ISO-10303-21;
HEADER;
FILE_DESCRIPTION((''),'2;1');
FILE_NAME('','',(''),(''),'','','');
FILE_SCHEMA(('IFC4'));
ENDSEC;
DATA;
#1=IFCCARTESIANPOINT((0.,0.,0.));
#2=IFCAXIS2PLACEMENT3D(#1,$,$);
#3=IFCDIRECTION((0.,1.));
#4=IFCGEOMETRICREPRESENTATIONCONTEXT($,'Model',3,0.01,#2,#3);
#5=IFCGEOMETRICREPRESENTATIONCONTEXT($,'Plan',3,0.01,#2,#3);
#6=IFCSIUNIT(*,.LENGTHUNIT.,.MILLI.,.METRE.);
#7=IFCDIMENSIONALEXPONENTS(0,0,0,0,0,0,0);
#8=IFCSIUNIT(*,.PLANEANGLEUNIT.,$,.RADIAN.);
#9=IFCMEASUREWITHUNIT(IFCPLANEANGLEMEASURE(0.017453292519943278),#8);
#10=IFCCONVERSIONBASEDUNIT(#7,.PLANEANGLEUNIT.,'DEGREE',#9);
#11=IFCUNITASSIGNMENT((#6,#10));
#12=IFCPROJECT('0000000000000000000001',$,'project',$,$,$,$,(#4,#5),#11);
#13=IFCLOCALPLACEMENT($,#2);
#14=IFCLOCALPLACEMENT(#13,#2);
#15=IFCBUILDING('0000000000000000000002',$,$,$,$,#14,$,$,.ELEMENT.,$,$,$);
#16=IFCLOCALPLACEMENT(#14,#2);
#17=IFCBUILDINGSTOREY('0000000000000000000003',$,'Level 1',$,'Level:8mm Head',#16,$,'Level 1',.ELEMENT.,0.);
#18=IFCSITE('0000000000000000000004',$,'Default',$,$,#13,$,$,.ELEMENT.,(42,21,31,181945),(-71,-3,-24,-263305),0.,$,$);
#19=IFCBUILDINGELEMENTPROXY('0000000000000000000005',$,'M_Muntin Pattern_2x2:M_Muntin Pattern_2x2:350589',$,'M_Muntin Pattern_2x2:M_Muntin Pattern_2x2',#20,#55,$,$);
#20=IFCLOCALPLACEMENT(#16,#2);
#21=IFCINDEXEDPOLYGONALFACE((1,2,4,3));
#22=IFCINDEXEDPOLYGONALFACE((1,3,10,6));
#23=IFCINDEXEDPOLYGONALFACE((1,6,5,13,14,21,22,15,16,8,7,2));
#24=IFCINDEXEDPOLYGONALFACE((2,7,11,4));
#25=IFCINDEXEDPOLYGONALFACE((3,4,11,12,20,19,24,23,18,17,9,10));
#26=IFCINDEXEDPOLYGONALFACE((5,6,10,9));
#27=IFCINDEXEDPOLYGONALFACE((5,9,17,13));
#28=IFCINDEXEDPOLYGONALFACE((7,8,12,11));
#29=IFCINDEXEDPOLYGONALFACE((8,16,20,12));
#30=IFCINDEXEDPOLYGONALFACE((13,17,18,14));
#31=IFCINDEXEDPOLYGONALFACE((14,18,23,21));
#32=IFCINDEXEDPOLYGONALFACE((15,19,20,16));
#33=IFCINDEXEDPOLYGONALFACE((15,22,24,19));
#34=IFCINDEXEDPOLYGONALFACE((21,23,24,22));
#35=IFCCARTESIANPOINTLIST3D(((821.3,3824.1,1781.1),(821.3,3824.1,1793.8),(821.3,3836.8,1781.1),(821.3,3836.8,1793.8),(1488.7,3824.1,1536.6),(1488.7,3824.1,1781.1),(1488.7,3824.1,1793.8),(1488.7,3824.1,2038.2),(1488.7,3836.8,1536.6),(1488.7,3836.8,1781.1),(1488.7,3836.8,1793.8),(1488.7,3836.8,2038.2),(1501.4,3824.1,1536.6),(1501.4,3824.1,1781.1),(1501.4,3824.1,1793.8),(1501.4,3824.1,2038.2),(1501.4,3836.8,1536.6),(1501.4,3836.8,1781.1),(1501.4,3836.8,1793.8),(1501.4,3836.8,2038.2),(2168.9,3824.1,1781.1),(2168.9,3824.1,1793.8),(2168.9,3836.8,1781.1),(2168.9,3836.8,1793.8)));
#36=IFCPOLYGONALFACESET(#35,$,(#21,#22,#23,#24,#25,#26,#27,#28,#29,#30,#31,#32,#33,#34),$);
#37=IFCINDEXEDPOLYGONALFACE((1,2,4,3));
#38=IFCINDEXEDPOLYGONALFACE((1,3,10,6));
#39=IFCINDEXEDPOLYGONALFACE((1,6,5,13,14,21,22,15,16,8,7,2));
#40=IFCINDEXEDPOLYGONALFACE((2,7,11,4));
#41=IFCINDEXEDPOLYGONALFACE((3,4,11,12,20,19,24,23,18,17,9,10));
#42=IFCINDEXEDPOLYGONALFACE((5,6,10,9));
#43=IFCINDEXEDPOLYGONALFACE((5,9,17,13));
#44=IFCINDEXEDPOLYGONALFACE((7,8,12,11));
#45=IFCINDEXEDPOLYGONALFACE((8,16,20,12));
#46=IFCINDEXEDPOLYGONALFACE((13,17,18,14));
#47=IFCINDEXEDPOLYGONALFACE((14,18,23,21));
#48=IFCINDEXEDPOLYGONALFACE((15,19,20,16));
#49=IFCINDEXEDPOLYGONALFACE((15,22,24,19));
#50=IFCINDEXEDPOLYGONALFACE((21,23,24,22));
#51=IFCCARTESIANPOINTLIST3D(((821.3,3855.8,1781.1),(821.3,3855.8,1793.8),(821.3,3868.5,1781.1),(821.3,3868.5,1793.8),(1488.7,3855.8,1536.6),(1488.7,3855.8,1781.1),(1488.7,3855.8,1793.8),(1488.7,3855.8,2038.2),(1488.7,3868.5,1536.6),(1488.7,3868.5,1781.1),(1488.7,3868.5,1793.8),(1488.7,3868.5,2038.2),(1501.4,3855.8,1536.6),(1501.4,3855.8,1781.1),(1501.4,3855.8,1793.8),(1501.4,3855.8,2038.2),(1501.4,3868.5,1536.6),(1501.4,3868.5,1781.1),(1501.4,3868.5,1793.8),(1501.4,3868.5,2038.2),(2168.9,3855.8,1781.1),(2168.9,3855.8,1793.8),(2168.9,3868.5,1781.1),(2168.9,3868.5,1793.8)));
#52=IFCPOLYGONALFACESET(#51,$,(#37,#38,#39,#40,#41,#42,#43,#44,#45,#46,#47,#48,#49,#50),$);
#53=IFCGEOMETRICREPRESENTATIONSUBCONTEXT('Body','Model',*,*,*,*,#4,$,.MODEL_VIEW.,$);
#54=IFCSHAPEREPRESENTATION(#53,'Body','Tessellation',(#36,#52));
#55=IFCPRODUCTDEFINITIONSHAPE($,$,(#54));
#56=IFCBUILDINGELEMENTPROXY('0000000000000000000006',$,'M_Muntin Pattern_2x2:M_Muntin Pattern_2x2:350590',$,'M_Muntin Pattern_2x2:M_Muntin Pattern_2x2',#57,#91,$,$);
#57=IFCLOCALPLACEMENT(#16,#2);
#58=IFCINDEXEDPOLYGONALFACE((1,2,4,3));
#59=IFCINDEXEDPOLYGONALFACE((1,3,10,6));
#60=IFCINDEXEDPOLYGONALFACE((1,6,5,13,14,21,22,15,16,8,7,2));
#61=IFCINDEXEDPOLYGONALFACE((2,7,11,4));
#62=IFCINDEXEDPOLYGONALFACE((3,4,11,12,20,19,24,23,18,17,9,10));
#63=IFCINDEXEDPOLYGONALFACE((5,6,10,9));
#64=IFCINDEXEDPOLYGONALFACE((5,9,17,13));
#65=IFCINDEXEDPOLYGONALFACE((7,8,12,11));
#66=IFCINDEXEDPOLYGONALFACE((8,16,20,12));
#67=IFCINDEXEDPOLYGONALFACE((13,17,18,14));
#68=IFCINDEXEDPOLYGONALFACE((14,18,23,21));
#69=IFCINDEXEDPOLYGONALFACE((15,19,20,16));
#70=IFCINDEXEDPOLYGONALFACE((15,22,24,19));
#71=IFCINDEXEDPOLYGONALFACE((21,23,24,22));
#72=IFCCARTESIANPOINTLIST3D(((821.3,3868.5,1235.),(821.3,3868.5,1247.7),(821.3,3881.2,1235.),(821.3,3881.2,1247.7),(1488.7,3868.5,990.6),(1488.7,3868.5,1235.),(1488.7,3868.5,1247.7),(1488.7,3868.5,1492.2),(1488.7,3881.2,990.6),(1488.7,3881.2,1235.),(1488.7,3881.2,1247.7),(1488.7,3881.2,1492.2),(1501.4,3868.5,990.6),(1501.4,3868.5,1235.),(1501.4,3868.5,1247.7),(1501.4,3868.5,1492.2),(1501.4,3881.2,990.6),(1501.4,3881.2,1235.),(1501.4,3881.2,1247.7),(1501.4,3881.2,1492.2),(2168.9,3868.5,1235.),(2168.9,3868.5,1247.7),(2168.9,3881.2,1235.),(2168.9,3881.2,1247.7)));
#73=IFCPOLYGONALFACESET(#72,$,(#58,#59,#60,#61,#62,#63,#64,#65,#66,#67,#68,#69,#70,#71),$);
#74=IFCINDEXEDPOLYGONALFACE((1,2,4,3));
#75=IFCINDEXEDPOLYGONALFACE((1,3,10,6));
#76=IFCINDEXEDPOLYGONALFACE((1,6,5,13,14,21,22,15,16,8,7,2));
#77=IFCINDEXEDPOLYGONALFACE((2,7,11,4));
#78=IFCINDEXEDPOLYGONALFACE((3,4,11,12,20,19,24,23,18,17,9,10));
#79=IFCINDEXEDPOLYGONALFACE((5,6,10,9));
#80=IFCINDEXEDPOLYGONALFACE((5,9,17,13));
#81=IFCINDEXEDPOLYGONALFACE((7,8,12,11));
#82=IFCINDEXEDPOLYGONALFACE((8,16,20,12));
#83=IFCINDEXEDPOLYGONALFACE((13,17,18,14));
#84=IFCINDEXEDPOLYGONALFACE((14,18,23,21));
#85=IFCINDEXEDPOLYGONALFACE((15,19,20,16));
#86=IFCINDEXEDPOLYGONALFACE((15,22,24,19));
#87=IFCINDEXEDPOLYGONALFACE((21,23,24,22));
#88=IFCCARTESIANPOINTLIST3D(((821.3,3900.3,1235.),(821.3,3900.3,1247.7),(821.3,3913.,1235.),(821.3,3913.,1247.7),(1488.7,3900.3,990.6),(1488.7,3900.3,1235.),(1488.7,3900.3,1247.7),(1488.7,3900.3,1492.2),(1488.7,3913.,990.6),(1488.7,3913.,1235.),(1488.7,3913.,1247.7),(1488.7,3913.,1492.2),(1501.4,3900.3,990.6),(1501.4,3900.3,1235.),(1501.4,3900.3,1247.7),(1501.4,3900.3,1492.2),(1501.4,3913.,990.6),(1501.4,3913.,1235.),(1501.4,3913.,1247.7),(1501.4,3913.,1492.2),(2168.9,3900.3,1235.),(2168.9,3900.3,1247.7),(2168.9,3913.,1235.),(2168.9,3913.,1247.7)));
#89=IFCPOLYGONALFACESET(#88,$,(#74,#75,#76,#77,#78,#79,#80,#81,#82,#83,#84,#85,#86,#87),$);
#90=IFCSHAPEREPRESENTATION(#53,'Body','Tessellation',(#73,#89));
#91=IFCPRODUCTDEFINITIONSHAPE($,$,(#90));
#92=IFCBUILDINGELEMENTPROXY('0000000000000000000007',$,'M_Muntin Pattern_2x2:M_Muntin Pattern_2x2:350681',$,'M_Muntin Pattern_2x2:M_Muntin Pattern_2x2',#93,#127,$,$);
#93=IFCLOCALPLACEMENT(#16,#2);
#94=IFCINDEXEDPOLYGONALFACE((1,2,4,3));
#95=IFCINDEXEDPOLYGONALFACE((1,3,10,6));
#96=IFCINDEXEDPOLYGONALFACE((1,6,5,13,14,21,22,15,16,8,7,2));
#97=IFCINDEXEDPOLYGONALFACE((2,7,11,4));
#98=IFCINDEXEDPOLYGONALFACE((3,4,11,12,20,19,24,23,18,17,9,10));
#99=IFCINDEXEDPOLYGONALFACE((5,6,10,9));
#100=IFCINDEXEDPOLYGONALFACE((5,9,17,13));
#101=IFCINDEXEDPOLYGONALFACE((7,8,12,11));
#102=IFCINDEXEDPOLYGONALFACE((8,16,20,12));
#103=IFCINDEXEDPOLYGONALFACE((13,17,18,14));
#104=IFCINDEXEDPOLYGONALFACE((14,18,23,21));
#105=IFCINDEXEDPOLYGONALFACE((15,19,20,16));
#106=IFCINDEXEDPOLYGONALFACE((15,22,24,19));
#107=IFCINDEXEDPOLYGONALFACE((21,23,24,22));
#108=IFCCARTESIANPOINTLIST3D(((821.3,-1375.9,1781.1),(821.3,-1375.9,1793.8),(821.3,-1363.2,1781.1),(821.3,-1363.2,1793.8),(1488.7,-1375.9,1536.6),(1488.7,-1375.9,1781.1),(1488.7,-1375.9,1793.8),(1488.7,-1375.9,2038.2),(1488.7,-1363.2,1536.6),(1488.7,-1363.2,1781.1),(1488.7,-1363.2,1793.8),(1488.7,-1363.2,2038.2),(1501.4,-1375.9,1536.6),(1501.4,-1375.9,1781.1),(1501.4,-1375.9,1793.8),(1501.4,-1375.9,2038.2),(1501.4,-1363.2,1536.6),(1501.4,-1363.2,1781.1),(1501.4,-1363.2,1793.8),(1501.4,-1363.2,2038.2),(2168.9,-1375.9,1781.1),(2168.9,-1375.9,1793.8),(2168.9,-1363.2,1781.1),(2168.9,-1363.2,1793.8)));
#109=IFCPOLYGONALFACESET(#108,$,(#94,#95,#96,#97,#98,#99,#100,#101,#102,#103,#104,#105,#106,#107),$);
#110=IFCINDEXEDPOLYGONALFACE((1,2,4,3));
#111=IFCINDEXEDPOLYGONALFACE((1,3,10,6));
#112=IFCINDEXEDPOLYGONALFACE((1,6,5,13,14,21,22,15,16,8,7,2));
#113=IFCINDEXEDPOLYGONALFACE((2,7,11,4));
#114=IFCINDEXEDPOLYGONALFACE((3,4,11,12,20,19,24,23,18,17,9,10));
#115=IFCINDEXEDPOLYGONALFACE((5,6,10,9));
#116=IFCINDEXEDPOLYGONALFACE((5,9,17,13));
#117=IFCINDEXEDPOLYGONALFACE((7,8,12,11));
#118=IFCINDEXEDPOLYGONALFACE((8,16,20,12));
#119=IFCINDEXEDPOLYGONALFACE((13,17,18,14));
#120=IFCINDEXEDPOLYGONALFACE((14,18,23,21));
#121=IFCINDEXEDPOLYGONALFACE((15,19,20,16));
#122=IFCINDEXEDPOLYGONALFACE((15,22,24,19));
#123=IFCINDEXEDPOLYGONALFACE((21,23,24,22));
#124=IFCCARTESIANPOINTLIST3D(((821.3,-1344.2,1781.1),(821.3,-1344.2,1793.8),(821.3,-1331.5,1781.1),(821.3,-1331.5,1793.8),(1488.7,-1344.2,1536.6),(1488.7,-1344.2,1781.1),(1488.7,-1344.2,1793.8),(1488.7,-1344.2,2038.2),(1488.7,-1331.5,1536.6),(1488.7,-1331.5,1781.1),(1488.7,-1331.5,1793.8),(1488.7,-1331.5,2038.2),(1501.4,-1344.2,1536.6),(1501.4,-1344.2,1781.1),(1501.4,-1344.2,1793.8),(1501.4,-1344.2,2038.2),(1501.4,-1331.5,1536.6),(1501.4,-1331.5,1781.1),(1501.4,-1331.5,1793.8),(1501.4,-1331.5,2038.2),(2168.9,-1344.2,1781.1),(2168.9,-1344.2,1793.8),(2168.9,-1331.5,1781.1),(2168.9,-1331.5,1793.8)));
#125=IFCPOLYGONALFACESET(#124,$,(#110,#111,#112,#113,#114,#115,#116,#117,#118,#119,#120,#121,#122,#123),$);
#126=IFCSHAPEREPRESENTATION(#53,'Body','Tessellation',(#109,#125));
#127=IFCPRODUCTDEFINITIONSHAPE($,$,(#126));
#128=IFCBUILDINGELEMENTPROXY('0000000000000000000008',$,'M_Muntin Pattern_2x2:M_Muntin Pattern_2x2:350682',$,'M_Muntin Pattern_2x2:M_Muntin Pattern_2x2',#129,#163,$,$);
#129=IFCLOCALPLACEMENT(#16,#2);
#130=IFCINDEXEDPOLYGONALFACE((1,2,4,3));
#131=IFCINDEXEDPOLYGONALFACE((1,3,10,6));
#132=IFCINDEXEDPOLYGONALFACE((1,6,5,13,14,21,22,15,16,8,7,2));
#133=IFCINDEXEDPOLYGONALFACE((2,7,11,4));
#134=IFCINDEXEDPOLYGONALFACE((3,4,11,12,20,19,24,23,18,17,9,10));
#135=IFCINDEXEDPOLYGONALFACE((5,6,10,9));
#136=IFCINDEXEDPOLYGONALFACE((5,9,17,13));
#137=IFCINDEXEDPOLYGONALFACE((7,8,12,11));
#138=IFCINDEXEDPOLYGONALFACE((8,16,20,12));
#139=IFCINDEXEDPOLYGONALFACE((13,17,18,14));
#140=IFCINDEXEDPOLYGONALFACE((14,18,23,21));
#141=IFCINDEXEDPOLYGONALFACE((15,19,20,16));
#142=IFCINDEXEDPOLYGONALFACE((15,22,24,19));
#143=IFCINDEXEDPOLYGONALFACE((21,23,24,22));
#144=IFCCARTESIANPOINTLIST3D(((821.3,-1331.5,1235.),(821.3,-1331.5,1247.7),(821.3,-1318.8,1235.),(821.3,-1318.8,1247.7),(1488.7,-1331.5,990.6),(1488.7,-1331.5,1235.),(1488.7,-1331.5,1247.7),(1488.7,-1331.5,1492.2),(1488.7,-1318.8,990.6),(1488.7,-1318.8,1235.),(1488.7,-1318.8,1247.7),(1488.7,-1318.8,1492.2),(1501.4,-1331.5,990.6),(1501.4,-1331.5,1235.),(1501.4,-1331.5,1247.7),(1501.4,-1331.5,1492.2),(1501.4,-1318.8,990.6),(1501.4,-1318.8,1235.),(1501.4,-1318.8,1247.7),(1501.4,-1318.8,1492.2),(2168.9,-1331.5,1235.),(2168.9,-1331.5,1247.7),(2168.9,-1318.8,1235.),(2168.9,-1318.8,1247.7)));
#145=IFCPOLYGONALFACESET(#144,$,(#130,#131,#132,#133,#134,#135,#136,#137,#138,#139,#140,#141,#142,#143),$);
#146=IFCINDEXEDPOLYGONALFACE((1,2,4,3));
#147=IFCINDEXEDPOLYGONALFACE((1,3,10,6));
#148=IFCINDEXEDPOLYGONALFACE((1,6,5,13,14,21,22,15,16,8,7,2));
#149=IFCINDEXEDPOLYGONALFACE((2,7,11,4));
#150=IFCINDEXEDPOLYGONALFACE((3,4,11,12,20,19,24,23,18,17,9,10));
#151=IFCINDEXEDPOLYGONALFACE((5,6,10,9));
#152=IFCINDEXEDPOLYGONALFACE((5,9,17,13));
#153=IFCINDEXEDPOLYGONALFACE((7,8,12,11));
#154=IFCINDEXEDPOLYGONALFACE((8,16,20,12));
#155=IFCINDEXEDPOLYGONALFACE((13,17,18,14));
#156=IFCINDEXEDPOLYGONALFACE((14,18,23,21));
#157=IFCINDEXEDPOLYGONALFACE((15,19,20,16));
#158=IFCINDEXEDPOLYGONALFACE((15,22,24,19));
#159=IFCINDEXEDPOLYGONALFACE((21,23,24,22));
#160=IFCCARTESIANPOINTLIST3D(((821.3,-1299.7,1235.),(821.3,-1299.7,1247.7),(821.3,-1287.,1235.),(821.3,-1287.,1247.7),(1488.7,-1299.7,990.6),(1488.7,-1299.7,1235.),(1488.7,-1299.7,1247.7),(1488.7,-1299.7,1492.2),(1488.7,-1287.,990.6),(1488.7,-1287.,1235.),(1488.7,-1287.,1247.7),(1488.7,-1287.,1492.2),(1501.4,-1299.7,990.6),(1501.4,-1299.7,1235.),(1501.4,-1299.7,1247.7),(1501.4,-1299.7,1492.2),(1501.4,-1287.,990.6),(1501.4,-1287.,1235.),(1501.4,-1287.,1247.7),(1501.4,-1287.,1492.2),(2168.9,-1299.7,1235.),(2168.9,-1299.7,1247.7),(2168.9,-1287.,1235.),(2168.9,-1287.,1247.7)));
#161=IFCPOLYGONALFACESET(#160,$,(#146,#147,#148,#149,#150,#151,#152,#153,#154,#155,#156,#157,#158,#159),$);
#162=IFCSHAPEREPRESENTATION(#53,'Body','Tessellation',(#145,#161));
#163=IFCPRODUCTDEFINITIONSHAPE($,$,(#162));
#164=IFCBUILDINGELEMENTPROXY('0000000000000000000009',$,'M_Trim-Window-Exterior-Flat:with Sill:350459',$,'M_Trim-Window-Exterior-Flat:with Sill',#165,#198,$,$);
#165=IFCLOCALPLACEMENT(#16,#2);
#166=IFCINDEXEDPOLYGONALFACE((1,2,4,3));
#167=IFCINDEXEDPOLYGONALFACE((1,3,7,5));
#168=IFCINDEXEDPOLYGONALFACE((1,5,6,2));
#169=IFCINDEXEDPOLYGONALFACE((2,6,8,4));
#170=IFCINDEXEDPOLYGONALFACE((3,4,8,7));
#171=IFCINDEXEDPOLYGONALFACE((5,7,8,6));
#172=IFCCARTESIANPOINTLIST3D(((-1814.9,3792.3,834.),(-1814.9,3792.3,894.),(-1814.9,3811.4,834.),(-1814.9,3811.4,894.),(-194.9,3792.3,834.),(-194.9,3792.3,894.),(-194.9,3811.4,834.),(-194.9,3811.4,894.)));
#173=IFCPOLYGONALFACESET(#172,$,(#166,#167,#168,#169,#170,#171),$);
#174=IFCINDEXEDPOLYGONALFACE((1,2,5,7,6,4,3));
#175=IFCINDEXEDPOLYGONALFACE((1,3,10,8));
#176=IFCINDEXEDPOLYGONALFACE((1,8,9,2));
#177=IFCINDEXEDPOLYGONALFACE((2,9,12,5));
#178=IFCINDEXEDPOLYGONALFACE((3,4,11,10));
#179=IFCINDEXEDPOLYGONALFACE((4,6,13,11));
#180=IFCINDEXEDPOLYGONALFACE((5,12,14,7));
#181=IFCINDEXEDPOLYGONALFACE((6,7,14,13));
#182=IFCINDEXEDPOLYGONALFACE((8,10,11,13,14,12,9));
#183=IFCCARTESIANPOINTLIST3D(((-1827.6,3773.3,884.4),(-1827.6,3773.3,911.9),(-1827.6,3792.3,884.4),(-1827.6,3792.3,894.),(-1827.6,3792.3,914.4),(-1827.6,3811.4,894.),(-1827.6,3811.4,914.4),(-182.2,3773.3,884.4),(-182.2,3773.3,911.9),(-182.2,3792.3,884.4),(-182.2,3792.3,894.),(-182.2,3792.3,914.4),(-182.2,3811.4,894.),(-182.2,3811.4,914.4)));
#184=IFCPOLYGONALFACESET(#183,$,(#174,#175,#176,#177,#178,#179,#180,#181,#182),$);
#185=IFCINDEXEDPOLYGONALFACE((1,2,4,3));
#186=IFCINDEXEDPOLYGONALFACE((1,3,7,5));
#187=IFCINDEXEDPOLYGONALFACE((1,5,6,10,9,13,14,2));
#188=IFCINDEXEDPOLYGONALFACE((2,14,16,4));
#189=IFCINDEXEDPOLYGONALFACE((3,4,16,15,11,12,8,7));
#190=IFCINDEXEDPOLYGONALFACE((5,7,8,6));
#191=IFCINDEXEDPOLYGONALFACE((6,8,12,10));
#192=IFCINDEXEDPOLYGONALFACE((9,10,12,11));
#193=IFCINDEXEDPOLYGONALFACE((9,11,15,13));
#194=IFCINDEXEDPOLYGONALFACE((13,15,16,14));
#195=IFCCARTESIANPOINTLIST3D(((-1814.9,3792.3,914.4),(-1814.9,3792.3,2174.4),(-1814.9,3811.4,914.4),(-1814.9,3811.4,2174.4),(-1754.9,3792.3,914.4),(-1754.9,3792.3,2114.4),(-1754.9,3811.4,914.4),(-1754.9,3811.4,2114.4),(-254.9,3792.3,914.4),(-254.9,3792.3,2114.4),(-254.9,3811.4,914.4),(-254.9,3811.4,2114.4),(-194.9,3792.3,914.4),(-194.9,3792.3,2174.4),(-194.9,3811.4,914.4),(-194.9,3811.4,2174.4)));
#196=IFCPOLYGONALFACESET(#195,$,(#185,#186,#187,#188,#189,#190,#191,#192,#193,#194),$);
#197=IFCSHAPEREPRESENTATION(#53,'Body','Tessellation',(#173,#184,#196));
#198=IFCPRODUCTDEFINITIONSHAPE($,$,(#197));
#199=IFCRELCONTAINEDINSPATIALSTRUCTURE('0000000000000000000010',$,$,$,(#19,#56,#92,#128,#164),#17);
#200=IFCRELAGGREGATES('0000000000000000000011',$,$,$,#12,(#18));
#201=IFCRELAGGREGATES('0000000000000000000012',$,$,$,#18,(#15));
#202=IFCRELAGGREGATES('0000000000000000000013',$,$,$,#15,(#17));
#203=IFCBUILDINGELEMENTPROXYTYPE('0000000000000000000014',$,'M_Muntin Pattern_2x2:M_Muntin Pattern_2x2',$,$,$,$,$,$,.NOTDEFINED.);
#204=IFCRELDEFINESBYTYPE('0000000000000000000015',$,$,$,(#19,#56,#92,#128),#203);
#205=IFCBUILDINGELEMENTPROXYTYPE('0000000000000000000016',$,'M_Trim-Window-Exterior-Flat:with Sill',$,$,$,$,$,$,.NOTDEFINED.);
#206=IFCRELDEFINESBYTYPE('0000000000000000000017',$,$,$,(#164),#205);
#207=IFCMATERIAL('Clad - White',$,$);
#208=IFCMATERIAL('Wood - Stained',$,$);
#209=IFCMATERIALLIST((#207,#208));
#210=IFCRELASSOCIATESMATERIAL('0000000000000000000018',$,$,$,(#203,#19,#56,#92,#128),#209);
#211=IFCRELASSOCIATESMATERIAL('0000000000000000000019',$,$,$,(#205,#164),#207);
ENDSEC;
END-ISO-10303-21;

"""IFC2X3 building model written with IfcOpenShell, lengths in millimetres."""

from ifc_helpers import new_model, entity, si_unit, converted_unit, direction, frame, frame_2d, origin, place, context, subcontext, project, spatial, polyline, rectangle, outline, extrude, source, transform, mapped, material, material_list, type_object, type_shapes, element, save


model = new_model("IFC2X3")

# Units and contexts
model_context = context("Model", 3, precision=0.01, world=origin(), true_north=direction((0.0, 1.0)))
plan_context = context("Plan", 3, precision=0.01, world=origin(), true_north=direction((0.0, 1.0)))
body_context = subcontext(model_context, "Body", "Model", "MODEL_VIEW")
ifc_project = project(units=[si_unit("LENGTHUNIT", "METRE", prefix="MILLI"), converted_unit("PLANEANGLEUNIT", "DEGREE", entity("IfcPlaneAngleMeasure", 0.017453292519943278), si_unit("PLANEANGLEUNIT", "RADIAN"), dimensions=[0, 0, 0, 0, 0, 0, 0])], contexts=[model_context, plan_context])

# Site, building, storey
site_placement = place(None, origin())
site = spatial("IfcSite", under=ifc_project, at=site_placement, Name="Default", CompositionType="ELEMENT", RefLatitude=(42, 21, 31, 181945), RefLongitude=(-71, -3, -24, -263305), RefElevation=0.0)
building_placement = place(site_placement, origin())
building = spatial("IfcBuilding", under=site, at=building_placement, CompositionType="ELEMENT")
storey_placement = place(building_placement, origin())
storey = spatial("IfcBuildingStorey", under=building, at=storey_placement, Name="Level 1", ObjectType="Level:8mm Head", LongName="Level 1", CompositionType="ELEMENT", Elevation=0.0)

# Shared definitions
ifc_material_1 = material(Name="Wood - Stained")

# Building element proxies
ifc_material_2 = material(Name="Clad - White")
ifc_material_list_1 = material_list([ifc_material_2, ifc_material_1])
building_element_proxy_type_1 = type_object("IfcBuildingElementProxyType", Name="M_Muntin Pattern_2x2:M_Muntin Pattern_2x2", PredefinedType="NOTDEFINED", material=ifc_material_list_1)
shared_shape_1 = source(origin(), body_context, "Body", "SweptSolid", [
    extrude(outline(polyline([(6.4, -6.4), (250.8, -6.4), (250.8, 6.3), (6.4, 6.3), (6.4, 673.8), (-6.3, 673.8), (-6.3, 6.3), (-250.8, 6.3), (-250.8, -6.4), (-6.3, -6.4), (-6.3, -673.8), (6.4, -673.8), (6.4, -6.4)])), frame((0.0, 9.5, 250.8), z_axis=(0.0, 1.0, 0.0), x_axis=(0.0, 0.0, 1.0)), (0.0, 0.0, 1.0), 12.7),
    extrude(outline(polyline([(6.4, -6.4), (250.8, -6.4), (250.8, 6.3), (6.4, 6.3), (6.4, 673.8), (-6.3, 673.8), (-6.3, 6.3), (-250.8, 6.3), (-250.8, -6.4), (-6.3, -6.4), (-6.3, -673.8), (6.4, -673.8), (6.4, -6.4)])), frame((0.0, -22.2, 250.8), z_axis=(0.0, 1.0, 0.0), x_axis=(0.0, 0.0, 1.0)), (0.0, 0.0, 1.0), 12.7),
])
type_shapes(building_element_proxy_type_1, [shared_shape_1])
for number, where, z_axis, x_axis, name in (
    (1, (1495.1, 3846.3, 1536.6), (0.0, 0.0, 1.0), (-1.0, 0.0, 0.0), "M_Muntin Pattern_2x2:M_Muntin Pattern_2x2:350589"),
    (2, (1495.1, 3890.7, 990.6), (0.0, 0.0, 1.0), (-1.0, 0.0, 0.0), "M_Muntin Pattern_2x2:M_Muntin Pattern_2x2:350590"),
    (3, (1495.1, -1353.7, 1536.6), (0.0, 0.0, 1.0), (-1.0, 0.0, 0.0), "M_Muntin Pattern_2x2:M_Muntin Pattern_2x2:350681"),
    (4, (1495.1, -1309.3, 990.6), (0.0, 0.0, 1.0), (-1.0, 0.0, 0.0), "M_Muntin Pattern_2x2:M_Muntin Pattern_2x2:350682"),
):
    element("IfcBuildingElementProxy", number, at=place(storey_placement, frame(where, z_axis=z_axis, x_axis=x_axis)), inside=storey, type_object=building_element_proxy_type_1, material=ifc_material_list_1, Name=name, ObjectType="M_Muntin Pattern_2x2:M_Muntin Pattern_2x2", context=body_context, shape_type="MappedRepresentation", body=[
        mapped(shared_shape_1, transform((0.0, 0.0, 0.0), scale=1.0)),
    ])
building_element_proxy_type_2 = type_object("IfcBuildingElementProxyType", Name="M_Trim-Window-Exterior-Flat:with Sill", PredefinedType="NOTDEFINED", material=ifc_material_2)
shared_shape_2 = source(origin(), body_context, "Body", "SweptSolid", [
    extrude(rectangle(XDim=1620.0, YDim=60.0, at=frame_2d((0.0, 0.0), x_axis=(1.0, 0.0))), frame((0.0, -1250.4, 0.0), z_axis=(0.0, 0.0, 1.0), x_axis=(-1.0, 0.0, 0.0)), (0.0, 0.0, 1.0), 19.0),
    extrude(outline(polyline([(-19.0, -15.2), (0.0, -15.2), (0.0, -5.7), (19.0, -5.7), (19.0, 14.8), (0.0, 14.8), (-19.0, 12.3), (-19.0, -15.2)])), frame((-822.7, -1214.8, 19.0), z_axis=(1.0, 0.0, 0.0), x_axis=(0.0, 0.0, -1.0)), (0.0, 0.0, 1.0), 1645.4),
    extrude(outline(polyline([(-645.0, -810.0), (615.0, -810.0), (615.0, -750.0), (-585.0, -750.0), (-585.0, 750.0), (615.0, 750.0), (615.0, 810.0), (-645.0, 810.0), (-645.0, -810.0)])), frame((0.0, -585.0, 0.0), z_axis=(0.0, 0.0, 1.0), x_axis=(0.0, -1.0, 0.0)), (0.0, 0.0, 1.0), 19.0),
])
type_shapes(building_element_proxy_type_2, [shared_shape_2])
for number, where, z_axis, x_axis, name in (
    (5, (-1004.9, 3811.4, 2114.4), (0.0, -1.0, 0.0), (1.0, 0.0, 0.0), "M_Trim-Window-Exterior-Flat:with Sill:350459"),
):
    element("IfcBuildingElementProxy", number, at=place(storey_placement, frame(where, z_axis=z_axis, x_axis=x_axis)), inside=storey, type_object=building_element_proxy_type_2, material=ifc_material_2, Name=name, ObjectType="M_Trim-Window-Exterior-Flat:with Sill", context=body_context, shape_type="MappedRepresentation", body=[
        mapped(shared_shape_2, transform((0.0, 0.0, 0.0), scale=1.0)),
    ])

save(model, "model.ifc")
